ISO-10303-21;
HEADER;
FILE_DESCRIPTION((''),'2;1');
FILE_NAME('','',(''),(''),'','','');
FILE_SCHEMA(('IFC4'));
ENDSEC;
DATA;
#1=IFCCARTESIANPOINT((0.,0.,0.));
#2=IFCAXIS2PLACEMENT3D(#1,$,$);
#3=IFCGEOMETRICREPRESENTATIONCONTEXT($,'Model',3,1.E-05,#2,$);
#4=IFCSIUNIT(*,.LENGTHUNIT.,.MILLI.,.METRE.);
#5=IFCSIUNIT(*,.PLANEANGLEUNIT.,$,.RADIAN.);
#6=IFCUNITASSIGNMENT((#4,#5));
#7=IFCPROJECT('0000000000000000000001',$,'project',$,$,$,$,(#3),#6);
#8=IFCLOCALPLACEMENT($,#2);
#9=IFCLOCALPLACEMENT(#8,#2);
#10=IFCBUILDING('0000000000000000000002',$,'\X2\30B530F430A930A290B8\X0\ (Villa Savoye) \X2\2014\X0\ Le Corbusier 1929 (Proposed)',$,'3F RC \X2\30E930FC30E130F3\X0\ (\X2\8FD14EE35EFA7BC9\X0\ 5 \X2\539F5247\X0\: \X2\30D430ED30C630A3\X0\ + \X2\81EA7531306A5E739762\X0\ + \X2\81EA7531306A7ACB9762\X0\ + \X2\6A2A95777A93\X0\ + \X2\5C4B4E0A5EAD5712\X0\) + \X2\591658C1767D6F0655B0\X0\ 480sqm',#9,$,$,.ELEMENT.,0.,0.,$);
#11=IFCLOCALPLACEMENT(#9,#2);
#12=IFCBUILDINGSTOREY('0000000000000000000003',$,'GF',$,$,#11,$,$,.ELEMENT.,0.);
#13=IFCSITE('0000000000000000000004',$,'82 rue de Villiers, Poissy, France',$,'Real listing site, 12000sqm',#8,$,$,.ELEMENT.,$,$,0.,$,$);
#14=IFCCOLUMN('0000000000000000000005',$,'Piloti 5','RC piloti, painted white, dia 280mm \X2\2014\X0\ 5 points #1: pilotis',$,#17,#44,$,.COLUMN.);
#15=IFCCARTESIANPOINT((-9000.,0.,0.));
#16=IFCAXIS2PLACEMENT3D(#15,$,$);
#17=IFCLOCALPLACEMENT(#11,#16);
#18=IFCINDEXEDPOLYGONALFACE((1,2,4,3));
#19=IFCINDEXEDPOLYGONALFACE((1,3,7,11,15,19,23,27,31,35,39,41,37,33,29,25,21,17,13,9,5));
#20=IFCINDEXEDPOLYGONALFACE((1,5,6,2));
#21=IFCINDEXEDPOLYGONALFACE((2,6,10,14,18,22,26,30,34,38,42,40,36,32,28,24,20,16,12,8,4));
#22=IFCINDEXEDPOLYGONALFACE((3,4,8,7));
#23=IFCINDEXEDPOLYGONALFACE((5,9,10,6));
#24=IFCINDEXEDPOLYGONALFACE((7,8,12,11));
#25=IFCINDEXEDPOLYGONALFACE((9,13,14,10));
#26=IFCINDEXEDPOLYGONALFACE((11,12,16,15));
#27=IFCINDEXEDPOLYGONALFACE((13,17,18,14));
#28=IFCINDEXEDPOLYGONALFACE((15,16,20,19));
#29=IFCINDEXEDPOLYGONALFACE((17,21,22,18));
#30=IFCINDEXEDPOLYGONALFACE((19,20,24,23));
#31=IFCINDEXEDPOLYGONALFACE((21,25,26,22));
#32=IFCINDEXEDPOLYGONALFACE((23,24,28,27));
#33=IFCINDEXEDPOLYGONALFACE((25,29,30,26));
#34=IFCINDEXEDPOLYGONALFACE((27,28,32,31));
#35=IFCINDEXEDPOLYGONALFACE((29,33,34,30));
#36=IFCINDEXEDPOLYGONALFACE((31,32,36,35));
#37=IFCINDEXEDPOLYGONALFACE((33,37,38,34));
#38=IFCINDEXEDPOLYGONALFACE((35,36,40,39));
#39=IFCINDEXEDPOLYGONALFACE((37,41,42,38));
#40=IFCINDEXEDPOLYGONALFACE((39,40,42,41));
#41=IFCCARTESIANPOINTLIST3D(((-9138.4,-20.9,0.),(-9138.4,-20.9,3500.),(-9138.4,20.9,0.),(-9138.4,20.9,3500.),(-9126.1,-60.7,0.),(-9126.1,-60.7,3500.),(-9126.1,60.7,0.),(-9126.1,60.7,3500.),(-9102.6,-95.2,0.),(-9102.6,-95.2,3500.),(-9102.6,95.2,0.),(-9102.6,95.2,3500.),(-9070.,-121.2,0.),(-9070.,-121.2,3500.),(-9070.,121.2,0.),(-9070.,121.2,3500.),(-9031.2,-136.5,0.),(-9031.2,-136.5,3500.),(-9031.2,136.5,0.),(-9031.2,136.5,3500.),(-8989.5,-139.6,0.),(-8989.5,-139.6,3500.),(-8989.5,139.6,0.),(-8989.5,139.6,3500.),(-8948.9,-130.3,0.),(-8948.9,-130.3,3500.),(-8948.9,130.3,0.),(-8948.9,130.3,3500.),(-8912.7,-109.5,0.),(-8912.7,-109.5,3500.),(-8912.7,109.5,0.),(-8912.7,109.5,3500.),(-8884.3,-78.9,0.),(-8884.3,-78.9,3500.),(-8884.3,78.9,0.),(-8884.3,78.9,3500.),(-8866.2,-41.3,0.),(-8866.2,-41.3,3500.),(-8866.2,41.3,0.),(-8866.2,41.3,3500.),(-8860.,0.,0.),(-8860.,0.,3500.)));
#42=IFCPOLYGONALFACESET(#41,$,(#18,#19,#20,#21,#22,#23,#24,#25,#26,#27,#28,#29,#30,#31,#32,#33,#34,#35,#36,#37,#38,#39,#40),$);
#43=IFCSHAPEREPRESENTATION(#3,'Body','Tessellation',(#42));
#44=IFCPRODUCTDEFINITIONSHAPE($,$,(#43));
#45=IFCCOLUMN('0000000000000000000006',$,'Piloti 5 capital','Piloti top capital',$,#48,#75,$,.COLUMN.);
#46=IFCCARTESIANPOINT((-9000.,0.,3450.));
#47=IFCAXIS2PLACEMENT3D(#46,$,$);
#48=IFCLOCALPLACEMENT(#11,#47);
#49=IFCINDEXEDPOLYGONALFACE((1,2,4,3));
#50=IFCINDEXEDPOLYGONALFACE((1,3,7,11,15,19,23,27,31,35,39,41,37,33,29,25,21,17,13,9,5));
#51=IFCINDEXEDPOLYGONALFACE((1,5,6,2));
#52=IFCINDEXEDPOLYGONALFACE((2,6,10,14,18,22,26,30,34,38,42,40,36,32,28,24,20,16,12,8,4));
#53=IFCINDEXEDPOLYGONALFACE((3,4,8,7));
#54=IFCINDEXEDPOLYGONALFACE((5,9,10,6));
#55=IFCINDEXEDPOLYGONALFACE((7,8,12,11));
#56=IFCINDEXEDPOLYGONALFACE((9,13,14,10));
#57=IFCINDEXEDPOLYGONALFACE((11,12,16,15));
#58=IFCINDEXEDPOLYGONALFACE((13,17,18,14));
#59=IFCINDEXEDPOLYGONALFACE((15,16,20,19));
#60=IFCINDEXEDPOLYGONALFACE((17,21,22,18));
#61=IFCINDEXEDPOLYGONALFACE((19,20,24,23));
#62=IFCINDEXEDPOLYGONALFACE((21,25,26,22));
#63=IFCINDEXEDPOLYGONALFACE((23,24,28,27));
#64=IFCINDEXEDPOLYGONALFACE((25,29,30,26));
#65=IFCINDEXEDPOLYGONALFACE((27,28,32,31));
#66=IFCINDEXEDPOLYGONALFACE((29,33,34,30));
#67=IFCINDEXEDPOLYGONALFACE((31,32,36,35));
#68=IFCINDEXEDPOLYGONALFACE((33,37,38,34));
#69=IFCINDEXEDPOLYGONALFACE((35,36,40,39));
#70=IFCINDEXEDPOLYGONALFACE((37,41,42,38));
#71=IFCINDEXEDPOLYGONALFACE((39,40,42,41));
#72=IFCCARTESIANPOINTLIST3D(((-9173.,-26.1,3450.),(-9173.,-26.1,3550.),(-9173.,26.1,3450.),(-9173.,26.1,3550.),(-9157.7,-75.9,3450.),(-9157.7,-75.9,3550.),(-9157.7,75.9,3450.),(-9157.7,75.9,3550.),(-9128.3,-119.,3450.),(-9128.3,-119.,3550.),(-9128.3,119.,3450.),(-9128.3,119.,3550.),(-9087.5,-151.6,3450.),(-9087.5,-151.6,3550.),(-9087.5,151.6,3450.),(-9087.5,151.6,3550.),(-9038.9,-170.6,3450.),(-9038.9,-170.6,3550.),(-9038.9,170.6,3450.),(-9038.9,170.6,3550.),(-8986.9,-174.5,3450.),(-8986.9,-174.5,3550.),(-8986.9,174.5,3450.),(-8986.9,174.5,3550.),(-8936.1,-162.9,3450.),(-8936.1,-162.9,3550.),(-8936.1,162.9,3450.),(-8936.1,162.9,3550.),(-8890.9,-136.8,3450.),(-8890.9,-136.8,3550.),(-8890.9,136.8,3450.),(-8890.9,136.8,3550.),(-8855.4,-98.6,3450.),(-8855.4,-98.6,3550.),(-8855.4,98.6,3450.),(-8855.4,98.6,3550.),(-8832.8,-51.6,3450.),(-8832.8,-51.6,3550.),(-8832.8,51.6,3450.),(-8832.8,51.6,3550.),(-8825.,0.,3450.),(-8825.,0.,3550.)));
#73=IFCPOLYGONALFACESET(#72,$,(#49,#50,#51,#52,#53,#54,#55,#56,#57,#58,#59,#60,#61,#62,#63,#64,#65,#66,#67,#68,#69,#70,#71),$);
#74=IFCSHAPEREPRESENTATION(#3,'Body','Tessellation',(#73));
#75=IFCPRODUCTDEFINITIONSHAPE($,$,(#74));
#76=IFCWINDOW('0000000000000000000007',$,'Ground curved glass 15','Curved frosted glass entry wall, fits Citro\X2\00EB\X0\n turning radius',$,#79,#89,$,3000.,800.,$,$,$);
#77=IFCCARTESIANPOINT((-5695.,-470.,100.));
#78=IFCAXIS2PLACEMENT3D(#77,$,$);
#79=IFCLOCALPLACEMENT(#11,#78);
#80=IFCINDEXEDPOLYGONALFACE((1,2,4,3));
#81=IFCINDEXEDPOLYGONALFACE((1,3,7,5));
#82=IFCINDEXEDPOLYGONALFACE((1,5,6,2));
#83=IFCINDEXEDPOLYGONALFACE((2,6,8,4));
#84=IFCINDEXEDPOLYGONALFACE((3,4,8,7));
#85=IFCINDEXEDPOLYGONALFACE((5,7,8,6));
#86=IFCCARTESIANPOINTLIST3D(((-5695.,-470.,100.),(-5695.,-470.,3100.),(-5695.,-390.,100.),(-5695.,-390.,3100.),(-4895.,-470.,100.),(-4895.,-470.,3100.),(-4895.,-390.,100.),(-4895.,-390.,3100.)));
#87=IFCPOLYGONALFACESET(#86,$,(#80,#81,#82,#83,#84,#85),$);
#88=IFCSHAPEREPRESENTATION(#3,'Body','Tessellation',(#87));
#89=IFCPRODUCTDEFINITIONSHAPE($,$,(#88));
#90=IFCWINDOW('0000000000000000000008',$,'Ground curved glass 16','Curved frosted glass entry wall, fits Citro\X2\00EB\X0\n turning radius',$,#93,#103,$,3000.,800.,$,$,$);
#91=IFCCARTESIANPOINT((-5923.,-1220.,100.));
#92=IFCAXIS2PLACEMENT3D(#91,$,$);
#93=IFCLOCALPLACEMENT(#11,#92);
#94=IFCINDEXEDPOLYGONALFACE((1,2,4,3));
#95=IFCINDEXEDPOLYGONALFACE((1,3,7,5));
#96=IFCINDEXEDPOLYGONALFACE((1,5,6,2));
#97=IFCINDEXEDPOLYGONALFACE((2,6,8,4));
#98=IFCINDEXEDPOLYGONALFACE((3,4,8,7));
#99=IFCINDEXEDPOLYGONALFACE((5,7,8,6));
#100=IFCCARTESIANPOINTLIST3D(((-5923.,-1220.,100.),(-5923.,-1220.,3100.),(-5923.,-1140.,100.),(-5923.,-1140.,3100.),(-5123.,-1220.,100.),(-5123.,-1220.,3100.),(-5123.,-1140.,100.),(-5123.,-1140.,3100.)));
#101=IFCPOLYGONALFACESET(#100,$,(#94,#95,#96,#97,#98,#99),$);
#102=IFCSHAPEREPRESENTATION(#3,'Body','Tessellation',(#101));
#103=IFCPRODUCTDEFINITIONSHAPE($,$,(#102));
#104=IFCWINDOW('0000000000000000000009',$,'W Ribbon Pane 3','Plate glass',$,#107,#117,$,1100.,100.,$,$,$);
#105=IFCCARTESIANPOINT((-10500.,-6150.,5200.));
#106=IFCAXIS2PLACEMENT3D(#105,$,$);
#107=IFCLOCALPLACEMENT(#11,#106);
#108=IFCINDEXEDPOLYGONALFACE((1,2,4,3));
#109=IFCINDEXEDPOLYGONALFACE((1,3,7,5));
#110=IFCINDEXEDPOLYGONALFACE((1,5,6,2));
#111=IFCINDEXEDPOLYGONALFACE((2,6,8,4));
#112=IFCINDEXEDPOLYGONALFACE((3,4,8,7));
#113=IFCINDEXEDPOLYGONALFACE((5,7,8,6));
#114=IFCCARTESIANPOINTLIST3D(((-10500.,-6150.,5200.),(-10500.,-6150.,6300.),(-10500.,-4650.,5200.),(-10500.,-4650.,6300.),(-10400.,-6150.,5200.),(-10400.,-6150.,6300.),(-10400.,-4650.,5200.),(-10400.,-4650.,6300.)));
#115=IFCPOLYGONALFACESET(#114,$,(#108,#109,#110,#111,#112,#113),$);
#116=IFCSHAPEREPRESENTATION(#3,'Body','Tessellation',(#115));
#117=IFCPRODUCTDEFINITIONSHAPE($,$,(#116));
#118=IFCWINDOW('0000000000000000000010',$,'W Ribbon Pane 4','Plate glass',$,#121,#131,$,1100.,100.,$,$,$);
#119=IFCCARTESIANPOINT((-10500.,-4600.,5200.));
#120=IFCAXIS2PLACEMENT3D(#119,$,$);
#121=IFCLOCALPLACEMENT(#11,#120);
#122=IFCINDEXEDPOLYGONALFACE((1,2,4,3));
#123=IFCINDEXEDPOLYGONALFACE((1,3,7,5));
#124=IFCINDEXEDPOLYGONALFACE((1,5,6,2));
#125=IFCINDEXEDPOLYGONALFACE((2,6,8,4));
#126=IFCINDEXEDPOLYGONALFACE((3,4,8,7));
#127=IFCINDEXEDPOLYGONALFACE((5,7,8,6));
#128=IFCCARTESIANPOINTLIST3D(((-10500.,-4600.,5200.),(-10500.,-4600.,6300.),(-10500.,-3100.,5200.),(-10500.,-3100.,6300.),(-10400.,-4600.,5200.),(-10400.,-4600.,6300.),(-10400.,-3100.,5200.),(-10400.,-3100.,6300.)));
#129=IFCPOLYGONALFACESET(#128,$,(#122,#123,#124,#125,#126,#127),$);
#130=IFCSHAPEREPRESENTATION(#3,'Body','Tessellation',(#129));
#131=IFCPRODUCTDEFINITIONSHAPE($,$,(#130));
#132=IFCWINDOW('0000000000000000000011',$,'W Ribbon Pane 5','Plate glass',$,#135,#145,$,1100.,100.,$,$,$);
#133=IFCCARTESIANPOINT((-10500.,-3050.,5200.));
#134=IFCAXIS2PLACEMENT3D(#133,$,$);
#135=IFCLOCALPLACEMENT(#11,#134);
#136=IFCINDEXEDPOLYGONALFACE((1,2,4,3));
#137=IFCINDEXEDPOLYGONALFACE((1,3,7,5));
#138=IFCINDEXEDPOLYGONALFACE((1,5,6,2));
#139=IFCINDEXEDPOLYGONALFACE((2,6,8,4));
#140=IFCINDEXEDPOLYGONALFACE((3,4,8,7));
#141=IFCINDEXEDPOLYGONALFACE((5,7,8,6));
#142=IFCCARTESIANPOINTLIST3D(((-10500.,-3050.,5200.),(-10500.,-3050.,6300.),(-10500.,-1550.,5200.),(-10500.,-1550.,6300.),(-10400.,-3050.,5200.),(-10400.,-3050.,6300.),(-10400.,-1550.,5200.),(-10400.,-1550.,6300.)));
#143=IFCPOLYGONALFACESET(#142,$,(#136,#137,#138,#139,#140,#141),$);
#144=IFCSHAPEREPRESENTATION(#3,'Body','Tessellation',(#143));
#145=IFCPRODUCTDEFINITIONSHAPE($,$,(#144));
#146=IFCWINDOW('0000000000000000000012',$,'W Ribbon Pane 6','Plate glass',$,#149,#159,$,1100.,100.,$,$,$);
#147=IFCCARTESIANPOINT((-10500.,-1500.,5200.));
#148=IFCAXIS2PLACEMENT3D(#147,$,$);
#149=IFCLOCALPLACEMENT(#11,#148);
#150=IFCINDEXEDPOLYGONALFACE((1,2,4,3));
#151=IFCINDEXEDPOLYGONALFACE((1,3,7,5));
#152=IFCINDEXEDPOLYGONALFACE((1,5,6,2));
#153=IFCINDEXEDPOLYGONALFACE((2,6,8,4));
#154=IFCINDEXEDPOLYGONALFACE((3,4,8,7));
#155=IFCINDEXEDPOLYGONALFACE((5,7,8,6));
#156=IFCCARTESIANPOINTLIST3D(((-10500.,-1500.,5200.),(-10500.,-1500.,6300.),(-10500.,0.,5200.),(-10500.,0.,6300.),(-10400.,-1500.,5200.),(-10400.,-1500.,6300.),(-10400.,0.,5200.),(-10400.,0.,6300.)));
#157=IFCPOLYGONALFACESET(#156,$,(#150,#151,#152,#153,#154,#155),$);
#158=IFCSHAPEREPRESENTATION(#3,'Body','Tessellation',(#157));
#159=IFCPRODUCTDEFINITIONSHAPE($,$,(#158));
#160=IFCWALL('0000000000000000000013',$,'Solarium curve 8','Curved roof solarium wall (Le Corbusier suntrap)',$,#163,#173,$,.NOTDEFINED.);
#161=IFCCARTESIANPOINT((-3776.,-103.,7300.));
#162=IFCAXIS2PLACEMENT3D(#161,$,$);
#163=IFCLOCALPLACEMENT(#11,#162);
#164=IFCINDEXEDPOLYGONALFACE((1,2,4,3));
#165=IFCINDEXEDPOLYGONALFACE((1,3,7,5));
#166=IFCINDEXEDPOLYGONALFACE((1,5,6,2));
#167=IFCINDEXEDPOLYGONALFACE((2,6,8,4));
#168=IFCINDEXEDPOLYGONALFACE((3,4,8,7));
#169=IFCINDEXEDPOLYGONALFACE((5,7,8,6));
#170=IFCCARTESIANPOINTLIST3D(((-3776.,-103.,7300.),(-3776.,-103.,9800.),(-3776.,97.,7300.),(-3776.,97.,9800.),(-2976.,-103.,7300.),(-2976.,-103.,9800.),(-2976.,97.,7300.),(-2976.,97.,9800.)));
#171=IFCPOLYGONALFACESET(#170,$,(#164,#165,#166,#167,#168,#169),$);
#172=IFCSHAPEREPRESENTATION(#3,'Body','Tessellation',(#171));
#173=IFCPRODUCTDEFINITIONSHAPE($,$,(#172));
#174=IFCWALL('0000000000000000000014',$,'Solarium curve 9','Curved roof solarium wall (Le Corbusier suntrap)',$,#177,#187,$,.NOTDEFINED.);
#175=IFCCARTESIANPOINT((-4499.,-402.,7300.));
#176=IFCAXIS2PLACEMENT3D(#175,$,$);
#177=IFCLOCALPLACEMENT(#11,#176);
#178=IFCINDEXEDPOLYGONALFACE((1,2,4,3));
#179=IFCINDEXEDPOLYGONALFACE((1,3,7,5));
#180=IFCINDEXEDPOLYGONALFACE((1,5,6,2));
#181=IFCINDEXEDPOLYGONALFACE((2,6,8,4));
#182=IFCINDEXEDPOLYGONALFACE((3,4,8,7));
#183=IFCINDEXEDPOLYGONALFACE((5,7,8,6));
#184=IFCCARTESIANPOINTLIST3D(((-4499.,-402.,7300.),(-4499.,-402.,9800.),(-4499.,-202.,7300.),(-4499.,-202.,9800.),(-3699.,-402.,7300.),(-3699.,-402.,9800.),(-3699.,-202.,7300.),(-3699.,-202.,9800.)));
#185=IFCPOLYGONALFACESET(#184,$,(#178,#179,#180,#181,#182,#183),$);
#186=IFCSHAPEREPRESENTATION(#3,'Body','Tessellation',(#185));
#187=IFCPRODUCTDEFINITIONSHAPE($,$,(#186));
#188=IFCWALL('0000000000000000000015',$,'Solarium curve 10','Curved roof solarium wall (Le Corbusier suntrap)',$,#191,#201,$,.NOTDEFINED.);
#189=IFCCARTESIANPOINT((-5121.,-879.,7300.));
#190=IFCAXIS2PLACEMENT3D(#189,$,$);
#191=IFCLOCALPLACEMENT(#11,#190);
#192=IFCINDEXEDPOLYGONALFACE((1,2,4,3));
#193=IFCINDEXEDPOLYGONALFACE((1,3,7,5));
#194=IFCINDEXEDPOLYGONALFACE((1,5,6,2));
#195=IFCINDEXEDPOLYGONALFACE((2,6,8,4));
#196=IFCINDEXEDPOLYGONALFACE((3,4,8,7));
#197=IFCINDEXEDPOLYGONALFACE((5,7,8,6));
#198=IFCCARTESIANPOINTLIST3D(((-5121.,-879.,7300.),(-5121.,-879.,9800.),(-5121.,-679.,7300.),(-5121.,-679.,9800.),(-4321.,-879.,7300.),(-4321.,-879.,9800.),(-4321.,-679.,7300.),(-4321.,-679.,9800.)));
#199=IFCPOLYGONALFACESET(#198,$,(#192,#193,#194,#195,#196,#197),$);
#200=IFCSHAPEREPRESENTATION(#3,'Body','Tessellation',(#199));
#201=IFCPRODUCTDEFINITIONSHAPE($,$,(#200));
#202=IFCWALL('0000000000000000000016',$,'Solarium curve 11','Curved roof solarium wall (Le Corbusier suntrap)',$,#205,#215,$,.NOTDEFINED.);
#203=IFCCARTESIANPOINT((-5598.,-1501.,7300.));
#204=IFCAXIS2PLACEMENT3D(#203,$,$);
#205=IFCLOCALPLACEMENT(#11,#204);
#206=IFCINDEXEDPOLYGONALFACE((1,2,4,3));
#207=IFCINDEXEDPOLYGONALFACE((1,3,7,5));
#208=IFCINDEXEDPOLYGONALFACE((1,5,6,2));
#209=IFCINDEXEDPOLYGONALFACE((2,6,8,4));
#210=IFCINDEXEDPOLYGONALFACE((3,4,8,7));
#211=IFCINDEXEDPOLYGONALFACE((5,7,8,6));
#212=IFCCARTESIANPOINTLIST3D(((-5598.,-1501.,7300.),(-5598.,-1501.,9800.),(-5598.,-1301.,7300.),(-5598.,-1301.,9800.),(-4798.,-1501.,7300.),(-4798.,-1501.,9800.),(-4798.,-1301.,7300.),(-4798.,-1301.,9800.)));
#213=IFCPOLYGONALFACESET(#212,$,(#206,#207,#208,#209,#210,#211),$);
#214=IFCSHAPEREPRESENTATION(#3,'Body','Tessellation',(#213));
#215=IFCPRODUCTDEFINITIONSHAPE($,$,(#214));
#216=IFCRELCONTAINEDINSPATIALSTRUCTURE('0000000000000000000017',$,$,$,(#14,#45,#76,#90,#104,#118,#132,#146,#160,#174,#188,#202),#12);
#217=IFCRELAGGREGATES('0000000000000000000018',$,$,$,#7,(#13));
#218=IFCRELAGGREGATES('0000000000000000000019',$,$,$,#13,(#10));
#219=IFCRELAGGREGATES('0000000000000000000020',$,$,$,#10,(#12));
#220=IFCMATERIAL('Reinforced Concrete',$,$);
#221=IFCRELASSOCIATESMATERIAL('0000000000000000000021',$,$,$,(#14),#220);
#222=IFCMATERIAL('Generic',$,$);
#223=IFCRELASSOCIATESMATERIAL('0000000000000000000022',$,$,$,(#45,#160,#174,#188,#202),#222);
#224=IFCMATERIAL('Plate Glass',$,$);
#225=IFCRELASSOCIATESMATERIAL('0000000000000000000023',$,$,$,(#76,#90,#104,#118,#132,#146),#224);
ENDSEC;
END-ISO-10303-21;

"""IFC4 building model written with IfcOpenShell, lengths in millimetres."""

from ifc_helpers import new_model, si_unit, frame, frame_2d, origin, origin_2d, place, context, project, spatial, rectangle, circle, extrude, material, element, save


model = new_model("IFC4")

# Units and contexts
model_context = context("Model", 3, precision=1e-05, world=origin())
ifc_project = project(units=[si_unit("LENGTHUNIT", "METRE", prefix="MILLI"), si_unit("PLANEANGLEUNIT", "RADIAN")], contexts=[model_context])

# Site, building, storey
site_placement = place(None, origin())
site = spatial("IfcSite", under=ifc_project, at=site_placement, Name="82 rue de Villiers, Poissy, France", ObjectType="Real listing site, 12000sqm", CompositionType="ELEMENT", RefElevation=0.0)
building_placement = place(site_placement, origin())
building = spatial("IfcBuilding", under=site, at=building_placement, Name="サヴォア邸 (Villa Savoye) — Le Corbusier 1929 (Proposed)", ObjectType="3F RC ラーメン (近代建築 5 原則: ピロティ + 自由な平面 + 自由な立面 + 横長窓 + 屋上庭園) + 外壁白漆喰 480sqm", CompositionType="ELEMENT", ElevationOfRefHeight=0.0, ElevationOfTerrain=0.0)
storey_placement = place(building_placement, origin())
storey = spatial("IfcBuildingStorey", under=building, at=storey_placement, Name="GF", CompositionType="ELEMENT", Elevation=0.0)

# Columns
ifc_material_1 = material(Name="Reinforced Concrete")
column_1_placement = place(storey_placement, frame((-9000.0, 0.0, 0.0)))
element("IfcColumn", 1, at=column_1_placement, inside=storey, material=ifc_material_1, Name="Piloti 5", Description="RC piloti, painted white, dia 280mm — 5 points #1: pilotis", PredefinedType="COLUMN", context=model_context, shape_type="SweptSolid", body=[
    extrude(circle(Radius=140.0, at=origin_2d()), frame((-9000.0, 0.0, 0.0)), (0.0, 0.0, 1.0), 3500.0),
])
ifc_material_2 = material(Name="Generic")
column_2_placement = place(storey_placement, frame((-9000.0, 0.0, 3450.0)))
element("IfcColumn", 2, at=column_2_placement, inside=storey, material=ifc_material_2, Name="Piloti 5 capital", Description="Piloti top capital", PredefinedType="COLUMN", context=model_context, shape_type="SweptSolid", body=[
    extrude(circle(Radius=175.0, at=origin_2d()), frame((-9000.0, 0.0, 3450.0)), (0.0, 0.0, 1.0), 100.0),
])

# Windows
ifc_material_3 = material(Name="Plate Glass")
window_1_placement = place(storey_placement, frame((-5695.0, -470.0, 100.0)))
element("IfcWindow", 3, at=window_1_placement, inside=storey, material=ifc_material_3, Name="Ground curved glass 15", Description="Curved frosted glass entry wall, fits Citroën turning radius", OverallHeight=3000.0, OverallWidth=800.0, context=model_context, shape_type="SweptSolid", body=[
    extrude(rectangle(XDim=800.0, YDim=80.0, at=frame_2d((400.0, 40.0))), frame((-5695.0, -470.0, 100.0)), (0.0, 0.0, 1.0), 3000.0),
])
window_2_placement = place(storey_placement, frame((-5923.0, -1220.0, 100.0)))
element("IfcWindow", 4, at=window_2_placement, inside=storey, material=ifc_material_3, Name="Ground curved glass 16", Description="Curved frosted glass entry wall, fits Citroën turning radius", OverallHeight=3000.0, OverallWidth=800.0, context=model_context, shape_type="SweptSolid", body=[
    extrude(rectangle(XDim=800.0, YDim=80.0, at=frame_2d((400.0, 40.0))), frame((-5923.0, -1220.0, 100.0)), (0.0, 0.0, 1.0), 3000.0),
])
window_3_placement = place(storey_placement, frame((-10500.0, -6150.0, 5200.0)))
element("IfcWindow", 5, at=window_3_placement, inside=storey, material=ifc_material_3, Name="W Ribbon Pane 3", Description="Plate glass", OverallHeight=1100.0, OverallWidth=100.0, context=model_context, shape_type="SweptSolid", body=[
    extrude(rectangle(XDim=100.0, YDim=1500.0, at=frame_2d((50.0, 750.0))), frame((-10500.0, -6150.0, 5200.0)), (0.0, 0.0, 1.0), 1100.0),
])
window_4_placement = place(storey_placement, frame((-10500.0, -4600.0, 5200.0)))
element("IfcWindow", 6, at=window_4_placement, inside=storey, material=ifc_material_3, Name="W Ribbon Pane 4", Description="Plate glass", OverallHeight=1100.0, OverallWidth=100.0, context=model_context, shape_type="SweptSolid", body=[
    extrude(rectangle(XDim=100.0, YDim=1500.0, at=frame_2d((50.0, 750.0))), frame((-10500.0, -4600.0, 5200.0)), (0.0, 0.0, 1.0), 1100.0),
])
window_5_placement = place(storey_placement, frame((-10500.0, -3050.0, 5200.0)))
element("IfcWindow", 7, at=window_5_placement, inside=storey, material=ifc_material_3, Name="W Ribbon Pane 5", Description="Plate glass", OverallHeight=1100.0, OverallWidth=100.0, context=model_context, shape_type="SweptSolid", body=[
    extrude(rectangle(XDim=100.0, YDim=1500.0, at=frame_2d((50.0, 750.0))), frame((-10500.0, -3050.0, 5200.0)), (0.0, 0.0, 1.0), 1100.0),
])
window_6_placement = place(storey_placement, frame((-10500.0, -1500.0, 5200.0)))
element("IfcWindow", 8, at=window_6_placement, inside=storey, material=ifc_material_3, Name="W Ribbon Pane 6", Description="Plate glass", OverallHeight=1100.0, OverallWidth=100.0, context=model_context, shape_type="SweptSolid", body=[
    extrude(rectangle(XDim=100.0, YDim=1500.0, at=frame_2d((50.0, 750.0))), frame((-10500.0, -1500.0, 5200.0)), (0.0, 0.0, 1.0), 1100.0),
])

# Walls
wall_1_placement = place(storey_placement, frame((-3776.0, -103.0, 7300.0)))
element("IfcWall", 9, at=wall_1_placement, inside=storey, material=ifc_material_2, Name="Solarium curve 8", Description="Curved roof solarium wall (Le Corbusier suntrap)", PredefinedType="NOTDEFINED", context=model_context, shape_type="SweptSolid", body=[
    extrude(rectangle(XDim=800.0, YDim=200.0, at=frame_2d((400.0, 100.0))), frame((-3776.0, -103.0, 7300.0)), (0.0, 0.0, 1.0), 2500.0),
])
wall_2_placement = place(storey_placement, frame((-4499.0, -402.0, 7300.0)))
element("IfcWall", 10, at=wall_2_placement, inside=storey, material=ifc_material_2, Name="Solarium curve 9", Description="Curved roof solarium wall (Le Corbusier suntrap)", PredefinedType="NOTDEFINED", context=model_context, shape_type="SweptSolid", body=[
    extrude(rectangle(XDim=800.0, YDim=200.0, at=frame_2d((400.0, 100.0))), frame((-4499.0, -402.0, 7300.0)), (0.0, 0.0, 1.0), 2500.0),
])
wall_3_placement = place(storey_placement, frame((-5121.0, -879.0, 7300.0)))
element("IfcWall", 11, at=wall_3_placement, inside=storey, material=ifc_material_2, Name="Solarium curve 10", Description="Curved roof solarium wall (Le Corbusier suntrap)", PredefinedType="NOTDEFINED", context=model_context, shape_type="SweptSolid", body=[
    extrude(rectangle(XDim=800.0, YDim=200.0, at=frame_2d((400.0, 100.0))), frame((-5121.0, -879.0, 7300.0)), (0.0, 0.0, 1.0), 2500.0),
])
wall_4_placement = place(storey_placement, frame((-5598.0, -1501.0, 7300.0)))
element("IfcWall", 12, at=wall_4_placement, inside=storey, material=ifc_material_2, Name="Solarium curve 11", Description="Curved roof solarium wall (Le Corbusier suntrap)", PredefinedType="NOTDEFINED", context=model_context, shape_type="SweptSolid", body=[
    extrude(rectangle(XDim=800.0, YDim=200.0, at=frame_2d((400.0, 100.0))), frame((-5598.0, -1501.0, 7300.0)), (0.0, 0.0, 1.0), 2500.0),
])

save(model, "model.ifc")
